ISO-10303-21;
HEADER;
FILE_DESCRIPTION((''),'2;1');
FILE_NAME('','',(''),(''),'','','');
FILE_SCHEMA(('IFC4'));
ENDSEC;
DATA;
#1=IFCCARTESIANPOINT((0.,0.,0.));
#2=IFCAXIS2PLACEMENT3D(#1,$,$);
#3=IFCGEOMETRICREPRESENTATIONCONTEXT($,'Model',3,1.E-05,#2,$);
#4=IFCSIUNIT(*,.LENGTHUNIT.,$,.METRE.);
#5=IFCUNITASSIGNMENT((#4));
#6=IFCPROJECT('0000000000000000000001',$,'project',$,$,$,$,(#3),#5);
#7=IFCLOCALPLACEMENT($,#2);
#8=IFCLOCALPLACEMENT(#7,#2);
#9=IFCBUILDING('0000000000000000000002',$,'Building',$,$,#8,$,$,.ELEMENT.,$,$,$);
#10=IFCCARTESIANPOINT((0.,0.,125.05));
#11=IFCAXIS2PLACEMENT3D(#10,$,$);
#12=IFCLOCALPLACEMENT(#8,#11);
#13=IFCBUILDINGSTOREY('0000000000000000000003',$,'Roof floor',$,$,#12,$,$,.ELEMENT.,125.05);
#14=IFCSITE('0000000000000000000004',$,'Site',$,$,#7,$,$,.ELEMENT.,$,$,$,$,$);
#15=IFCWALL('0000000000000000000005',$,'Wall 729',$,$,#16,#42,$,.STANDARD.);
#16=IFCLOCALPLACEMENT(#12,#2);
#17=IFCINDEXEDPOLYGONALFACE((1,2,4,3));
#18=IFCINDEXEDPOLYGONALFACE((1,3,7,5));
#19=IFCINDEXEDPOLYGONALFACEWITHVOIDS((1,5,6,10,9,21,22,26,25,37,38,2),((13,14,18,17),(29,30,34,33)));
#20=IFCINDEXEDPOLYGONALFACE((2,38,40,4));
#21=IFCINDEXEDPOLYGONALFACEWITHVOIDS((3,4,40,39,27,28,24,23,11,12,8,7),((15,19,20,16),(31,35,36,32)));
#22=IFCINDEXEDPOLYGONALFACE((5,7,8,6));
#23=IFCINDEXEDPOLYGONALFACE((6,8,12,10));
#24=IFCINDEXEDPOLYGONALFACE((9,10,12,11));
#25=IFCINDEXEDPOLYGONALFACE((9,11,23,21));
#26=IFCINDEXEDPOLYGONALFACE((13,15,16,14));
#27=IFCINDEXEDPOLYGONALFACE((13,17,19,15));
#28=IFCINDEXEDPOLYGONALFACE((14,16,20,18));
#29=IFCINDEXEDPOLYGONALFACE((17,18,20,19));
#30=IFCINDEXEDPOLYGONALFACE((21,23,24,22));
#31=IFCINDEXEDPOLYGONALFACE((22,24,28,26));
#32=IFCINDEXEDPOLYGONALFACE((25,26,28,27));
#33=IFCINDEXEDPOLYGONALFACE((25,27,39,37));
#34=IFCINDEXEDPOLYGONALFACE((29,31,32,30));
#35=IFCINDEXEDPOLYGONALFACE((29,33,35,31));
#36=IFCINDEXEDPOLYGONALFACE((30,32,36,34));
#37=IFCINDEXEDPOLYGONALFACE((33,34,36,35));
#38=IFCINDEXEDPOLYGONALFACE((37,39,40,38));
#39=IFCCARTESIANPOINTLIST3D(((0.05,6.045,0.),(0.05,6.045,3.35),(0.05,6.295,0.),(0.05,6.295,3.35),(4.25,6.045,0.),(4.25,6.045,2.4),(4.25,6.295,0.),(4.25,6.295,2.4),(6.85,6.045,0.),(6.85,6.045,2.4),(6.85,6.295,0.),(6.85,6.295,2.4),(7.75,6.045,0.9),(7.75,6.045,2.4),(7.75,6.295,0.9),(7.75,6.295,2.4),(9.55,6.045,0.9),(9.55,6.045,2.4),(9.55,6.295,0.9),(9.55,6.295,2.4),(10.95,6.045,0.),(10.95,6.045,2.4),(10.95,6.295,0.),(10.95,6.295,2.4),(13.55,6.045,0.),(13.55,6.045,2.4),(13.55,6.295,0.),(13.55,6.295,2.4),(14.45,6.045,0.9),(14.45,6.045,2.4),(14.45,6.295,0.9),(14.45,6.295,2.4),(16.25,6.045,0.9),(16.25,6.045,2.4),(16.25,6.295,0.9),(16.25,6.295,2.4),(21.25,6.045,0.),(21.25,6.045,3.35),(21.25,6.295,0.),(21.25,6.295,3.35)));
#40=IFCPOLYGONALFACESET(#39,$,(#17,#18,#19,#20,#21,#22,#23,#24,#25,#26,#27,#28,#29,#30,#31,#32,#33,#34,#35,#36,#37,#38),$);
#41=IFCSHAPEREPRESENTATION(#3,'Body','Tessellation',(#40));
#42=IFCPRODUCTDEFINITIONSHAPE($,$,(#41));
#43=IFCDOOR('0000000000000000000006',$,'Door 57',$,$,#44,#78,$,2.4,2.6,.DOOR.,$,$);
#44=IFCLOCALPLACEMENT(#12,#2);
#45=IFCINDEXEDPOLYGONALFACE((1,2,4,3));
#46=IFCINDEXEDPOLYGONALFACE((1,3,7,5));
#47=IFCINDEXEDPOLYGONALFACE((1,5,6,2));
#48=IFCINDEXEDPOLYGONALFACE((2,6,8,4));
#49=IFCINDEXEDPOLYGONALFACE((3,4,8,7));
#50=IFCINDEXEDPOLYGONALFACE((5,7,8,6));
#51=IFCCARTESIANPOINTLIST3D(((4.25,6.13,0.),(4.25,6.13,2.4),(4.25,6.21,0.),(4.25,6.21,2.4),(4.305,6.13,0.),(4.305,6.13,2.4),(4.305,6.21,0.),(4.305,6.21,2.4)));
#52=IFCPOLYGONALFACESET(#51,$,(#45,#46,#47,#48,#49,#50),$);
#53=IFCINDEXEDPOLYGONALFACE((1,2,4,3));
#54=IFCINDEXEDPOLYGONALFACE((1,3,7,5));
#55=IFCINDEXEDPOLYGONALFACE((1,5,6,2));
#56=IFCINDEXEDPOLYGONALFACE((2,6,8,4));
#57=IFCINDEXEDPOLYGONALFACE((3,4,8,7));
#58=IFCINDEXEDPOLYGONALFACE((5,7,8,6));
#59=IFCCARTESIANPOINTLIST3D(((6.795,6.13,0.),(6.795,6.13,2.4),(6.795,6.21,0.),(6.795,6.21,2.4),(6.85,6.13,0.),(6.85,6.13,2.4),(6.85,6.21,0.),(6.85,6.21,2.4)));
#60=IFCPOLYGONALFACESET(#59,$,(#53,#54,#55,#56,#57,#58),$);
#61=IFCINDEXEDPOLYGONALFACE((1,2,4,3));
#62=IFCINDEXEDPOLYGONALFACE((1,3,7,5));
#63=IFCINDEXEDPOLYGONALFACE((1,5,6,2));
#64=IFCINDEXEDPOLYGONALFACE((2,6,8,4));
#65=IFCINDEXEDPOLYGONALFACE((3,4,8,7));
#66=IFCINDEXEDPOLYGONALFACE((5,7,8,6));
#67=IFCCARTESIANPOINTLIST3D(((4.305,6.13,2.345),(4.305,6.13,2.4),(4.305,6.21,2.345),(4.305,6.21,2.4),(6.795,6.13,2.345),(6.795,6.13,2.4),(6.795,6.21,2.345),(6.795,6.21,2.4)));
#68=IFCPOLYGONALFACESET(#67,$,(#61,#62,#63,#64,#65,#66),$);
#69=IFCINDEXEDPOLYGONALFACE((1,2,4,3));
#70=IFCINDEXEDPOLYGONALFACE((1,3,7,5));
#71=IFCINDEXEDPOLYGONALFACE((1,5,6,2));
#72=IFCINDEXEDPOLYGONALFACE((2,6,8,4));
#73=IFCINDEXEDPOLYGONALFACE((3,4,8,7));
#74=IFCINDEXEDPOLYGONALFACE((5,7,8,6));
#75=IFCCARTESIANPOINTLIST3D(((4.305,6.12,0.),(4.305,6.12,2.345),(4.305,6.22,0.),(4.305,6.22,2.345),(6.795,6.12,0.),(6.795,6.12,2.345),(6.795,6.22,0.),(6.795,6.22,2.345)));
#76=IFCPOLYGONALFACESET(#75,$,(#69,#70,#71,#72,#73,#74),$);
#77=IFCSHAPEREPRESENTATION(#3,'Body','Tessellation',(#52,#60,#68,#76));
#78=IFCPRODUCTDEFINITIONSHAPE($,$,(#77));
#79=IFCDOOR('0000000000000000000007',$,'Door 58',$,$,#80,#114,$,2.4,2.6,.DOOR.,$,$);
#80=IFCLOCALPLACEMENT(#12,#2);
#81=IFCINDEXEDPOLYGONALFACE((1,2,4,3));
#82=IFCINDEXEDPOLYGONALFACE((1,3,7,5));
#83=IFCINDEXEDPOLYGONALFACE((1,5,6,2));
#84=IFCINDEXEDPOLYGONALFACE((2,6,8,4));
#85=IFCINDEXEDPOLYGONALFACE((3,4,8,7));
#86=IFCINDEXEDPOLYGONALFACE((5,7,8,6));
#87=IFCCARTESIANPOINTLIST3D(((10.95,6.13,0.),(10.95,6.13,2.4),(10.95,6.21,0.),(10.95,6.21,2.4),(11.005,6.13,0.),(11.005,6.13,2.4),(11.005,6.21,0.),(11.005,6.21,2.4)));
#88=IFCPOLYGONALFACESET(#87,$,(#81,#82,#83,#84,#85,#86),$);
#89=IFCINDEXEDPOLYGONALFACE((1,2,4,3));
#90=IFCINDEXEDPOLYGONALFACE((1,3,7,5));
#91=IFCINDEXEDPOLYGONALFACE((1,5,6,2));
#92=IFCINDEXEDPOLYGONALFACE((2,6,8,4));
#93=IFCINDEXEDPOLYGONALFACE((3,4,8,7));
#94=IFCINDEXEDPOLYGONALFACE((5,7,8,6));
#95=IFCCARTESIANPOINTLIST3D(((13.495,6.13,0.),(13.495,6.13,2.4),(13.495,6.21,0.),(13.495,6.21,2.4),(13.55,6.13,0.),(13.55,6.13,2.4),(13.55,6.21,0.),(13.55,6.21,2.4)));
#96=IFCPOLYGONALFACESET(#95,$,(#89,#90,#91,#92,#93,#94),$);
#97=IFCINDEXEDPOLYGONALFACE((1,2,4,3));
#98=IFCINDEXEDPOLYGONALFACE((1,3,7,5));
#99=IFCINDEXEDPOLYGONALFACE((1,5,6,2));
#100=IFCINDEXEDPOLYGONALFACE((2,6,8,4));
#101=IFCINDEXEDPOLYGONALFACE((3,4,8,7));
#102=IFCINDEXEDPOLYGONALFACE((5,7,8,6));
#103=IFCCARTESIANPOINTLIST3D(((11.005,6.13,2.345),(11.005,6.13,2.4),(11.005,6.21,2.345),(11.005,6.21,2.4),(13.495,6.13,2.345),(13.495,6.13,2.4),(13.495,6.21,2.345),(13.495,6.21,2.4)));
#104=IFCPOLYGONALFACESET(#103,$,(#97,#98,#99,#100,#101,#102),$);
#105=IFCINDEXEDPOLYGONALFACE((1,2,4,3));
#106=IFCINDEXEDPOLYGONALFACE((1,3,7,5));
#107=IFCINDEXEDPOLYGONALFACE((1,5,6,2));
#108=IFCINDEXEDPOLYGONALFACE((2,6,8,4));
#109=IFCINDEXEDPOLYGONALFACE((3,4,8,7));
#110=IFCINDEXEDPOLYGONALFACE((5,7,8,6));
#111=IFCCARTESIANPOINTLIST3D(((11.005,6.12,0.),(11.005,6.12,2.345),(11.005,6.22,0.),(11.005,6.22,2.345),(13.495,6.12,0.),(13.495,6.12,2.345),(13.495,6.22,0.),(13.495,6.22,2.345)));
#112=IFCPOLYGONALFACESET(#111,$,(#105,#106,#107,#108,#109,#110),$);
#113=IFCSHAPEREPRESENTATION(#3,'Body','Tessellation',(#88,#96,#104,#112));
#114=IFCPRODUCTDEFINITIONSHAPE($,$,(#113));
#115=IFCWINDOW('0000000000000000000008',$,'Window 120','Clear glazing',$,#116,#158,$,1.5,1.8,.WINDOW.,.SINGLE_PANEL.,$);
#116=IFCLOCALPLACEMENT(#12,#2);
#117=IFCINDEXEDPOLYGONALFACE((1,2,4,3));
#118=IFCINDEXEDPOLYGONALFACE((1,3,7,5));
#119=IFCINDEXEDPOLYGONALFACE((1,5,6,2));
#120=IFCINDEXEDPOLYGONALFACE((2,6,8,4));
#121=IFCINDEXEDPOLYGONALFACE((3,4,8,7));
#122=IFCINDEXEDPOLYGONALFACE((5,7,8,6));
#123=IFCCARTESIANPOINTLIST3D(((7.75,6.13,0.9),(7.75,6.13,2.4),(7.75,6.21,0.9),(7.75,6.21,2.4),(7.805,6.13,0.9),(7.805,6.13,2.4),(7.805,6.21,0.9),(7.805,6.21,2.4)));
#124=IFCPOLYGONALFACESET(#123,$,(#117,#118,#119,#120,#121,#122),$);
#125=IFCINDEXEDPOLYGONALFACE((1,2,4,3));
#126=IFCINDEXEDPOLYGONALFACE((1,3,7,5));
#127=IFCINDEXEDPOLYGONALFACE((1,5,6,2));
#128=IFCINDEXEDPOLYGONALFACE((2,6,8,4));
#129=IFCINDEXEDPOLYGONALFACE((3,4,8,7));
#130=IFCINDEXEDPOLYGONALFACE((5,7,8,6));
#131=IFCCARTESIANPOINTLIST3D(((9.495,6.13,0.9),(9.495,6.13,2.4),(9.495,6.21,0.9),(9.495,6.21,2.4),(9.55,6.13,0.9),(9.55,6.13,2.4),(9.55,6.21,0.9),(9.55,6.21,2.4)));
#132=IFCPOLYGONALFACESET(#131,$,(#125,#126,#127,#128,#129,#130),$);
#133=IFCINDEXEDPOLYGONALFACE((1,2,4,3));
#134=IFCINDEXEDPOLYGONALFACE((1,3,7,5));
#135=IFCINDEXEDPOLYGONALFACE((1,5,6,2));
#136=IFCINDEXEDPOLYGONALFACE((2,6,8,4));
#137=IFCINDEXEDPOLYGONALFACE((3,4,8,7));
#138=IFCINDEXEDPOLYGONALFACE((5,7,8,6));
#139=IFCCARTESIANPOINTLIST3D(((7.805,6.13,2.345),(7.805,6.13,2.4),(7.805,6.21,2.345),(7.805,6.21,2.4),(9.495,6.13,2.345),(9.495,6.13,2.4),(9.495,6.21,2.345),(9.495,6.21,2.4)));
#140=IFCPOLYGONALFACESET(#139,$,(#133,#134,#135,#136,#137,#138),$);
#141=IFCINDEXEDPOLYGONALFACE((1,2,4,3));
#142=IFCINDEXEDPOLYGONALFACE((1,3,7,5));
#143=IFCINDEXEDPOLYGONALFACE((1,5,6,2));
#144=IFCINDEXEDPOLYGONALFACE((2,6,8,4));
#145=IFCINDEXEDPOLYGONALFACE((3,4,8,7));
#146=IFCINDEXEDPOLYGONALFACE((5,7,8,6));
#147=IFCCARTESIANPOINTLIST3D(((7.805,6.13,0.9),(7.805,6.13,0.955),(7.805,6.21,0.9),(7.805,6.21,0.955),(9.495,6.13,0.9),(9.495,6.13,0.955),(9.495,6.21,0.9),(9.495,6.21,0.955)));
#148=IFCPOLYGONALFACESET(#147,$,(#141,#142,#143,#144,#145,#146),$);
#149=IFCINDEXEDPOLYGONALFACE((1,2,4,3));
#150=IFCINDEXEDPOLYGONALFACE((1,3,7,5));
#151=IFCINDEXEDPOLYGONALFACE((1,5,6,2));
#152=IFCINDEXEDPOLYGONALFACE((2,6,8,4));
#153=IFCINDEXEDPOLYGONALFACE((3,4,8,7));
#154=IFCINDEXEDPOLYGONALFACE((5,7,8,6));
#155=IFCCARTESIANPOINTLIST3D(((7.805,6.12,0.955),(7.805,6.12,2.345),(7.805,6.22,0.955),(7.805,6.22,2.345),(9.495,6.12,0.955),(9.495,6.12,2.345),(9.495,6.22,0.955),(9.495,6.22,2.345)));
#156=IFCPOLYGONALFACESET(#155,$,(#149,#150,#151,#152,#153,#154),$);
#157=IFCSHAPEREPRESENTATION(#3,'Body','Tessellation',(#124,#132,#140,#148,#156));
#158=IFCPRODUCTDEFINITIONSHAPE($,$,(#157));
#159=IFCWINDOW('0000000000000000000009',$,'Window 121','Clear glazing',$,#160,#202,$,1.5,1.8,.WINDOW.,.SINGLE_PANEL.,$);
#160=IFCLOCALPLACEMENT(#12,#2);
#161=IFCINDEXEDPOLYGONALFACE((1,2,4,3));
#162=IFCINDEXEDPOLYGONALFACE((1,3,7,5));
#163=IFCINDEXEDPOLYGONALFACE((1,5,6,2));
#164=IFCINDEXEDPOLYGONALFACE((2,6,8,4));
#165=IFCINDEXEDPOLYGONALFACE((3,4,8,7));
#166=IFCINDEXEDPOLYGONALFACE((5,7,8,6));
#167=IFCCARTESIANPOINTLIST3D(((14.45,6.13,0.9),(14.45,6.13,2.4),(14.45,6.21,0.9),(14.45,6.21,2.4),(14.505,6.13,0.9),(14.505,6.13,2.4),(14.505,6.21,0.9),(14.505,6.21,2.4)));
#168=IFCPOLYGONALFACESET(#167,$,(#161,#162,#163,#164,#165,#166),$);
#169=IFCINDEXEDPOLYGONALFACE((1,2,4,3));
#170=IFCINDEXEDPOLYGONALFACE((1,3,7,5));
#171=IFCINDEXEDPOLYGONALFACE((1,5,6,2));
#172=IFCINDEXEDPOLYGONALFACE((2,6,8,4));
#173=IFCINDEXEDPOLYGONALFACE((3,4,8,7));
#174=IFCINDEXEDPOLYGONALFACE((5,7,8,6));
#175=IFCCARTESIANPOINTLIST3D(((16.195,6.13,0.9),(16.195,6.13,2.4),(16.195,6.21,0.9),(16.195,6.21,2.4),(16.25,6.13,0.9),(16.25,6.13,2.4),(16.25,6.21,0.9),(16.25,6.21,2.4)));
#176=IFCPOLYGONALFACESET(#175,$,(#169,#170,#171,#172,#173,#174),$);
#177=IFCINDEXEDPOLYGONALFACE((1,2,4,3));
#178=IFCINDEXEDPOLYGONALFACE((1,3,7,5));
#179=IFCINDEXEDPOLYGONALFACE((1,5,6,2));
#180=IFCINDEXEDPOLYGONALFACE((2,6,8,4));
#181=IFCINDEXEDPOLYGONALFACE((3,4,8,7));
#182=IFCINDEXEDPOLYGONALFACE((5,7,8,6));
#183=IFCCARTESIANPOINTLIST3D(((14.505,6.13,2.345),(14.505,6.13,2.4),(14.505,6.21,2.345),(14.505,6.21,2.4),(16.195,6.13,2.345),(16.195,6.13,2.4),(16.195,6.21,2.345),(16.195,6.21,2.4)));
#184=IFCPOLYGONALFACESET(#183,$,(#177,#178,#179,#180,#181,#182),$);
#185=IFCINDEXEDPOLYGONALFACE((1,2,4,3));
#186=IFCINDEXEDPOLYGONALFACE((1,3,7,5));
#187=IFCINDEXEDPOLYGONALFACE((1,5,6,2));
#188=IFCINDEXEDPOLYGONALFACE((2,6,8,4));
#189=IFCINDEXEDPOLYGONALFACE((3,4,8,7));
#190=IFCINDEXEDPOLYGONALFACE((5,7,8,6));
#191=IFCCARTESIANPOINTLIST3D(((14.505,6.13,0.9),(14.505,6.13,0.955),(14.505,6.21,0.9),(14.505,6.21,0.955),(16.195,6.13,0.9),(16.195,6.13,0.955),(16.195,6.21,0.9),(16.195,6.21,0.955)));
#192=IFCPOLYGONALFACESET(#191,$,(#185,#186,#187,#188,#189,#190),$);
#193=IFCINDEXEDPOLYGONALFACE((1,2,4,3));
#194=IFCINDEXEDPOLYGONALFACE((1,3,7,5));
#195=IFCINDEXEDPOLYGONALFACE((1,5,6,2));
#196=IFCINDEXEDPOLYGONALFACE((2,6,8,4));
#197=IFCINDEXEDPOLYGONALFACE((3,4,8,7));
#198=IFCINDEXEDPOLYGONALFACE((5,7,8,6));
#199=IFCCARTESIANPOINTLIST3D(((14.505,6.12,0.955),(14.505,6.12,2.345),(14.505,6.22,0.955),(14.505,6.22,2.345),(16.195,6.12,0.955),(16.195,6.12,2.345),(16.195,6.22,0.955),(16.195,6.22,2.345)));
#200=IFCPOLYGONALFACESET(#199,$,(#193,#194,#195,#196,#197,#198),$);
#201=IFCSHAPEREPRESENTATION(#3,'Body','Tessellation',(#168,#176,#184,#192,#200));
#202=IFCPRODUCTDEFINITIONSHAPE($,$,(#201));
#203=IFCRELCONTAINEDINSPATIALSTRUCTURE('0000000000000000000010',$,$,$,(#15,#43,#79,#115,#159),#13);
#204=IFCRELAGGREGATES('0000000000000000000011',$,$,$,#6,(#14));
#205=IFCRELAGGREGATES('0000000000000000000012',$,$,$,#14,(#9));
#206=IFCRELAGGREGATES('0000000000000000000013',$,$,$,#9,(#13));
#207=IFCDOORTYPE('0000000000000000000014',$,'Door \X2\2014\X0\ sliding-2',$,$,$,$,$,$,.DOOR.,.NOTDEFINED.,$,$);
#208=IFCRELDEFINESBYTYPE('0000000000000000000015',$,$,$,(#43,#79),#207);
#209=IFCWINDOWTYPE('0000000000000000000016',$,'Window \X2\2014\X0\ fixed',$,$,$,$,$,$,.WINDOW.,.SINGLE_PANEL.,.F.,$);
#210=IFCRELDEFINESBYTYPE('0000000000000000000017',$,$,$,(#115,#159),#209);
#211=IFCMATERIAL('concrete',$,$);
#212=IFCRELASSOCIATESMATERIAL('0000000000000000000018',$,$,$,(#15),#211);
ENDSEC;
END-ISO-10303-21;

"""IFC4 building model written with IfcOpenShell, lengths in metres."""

from ifc_helpers import new_model, si_unit, frame, frame_2d, origin, place, context, project, spatial, rectangle, extrude, material, type_object, element, fill, save


model = new_model("IFC4")

# Units and contexts
model_context = context("Model", 3, precision=1e-05, world=origin())
ifc_project = project(units=[si_unit("LENGTHUNIT", "METRE")], contexts=[model_context])

# Site, building, storey
site_placement = place(None, origin())
site = spatial("IfcSite", under=ifc_project, at=site_placement, Name="Site", CompositionType="ELEMENT")
building_placement = place(site_placement, origin())
building = spatial("IfcBuilding", under=site, at=building_placement, Name="Building", CompositionType="ELEMENT")
storey_placement = place(building_placement, frame((0.0, 0.0, 125.05)))
storey = spatial("IfcBuildingStorey", under=building, at=storey_placement, Name="Roof floor", CompositionType="ELEMENT", Elevation=125.05)

# Shared definitions
ifc_material = material(Name="concrete")

# Wall, openings, doors, windows
wall_1_placement = place(storey_placement, frame((0.05, 6.17, 0.0), z_axis=(0.0, 0.0, 1.0), x_axis=(1.0, 0.0, 0.0)))
wall_1 = element("IfcWall", 1, at=wall_1_placement, inside=storey, material=ifc_material, Name="Wall 729", PredefinedType="STANDARD", context=model_context, shape_type="SweptSolid", body=[
    extrude(rectangle(XDim=21.2, YDim=0.25, at=frame_2d((10.6, 0.0))), origin(), (0.0, 0.0, 1.0), 3.35),
])
opening_1_placement = place(storey_placement, frame((4.25, 6.17, 0.0), z_axis=(0.0, 0.0, 1.0), x_axis=(1.0, 0.0, 0.0)))
opening_1 = element("IfcOpeningElement", 2, at=opening_1_placement, cuts=wall_1, PredefinedType="OPENING", context=model_context, shape_type="SweptSolid", body=[
    extrude(rectangle(XDim=2.6, YDim=0.31, at=frame_2d((1.3, 0.0))), origin(), (0.0, 0.0, 1.0), 2.4),
])
opening_2_placement = place(storey_placement, frame((7.75, 6.17, 0.9), z_axis=(0.0, 0.0, 1.0), x_axis=(1.0, 0.0, 0.0)))
opening_2 = element("IfcOpeningElement", 3, at=opening_2_placement, cuts=wall_1, PredefinedType="OPENING", context=model_context, shape_type="SweptSolid", body=[
    extrude(rectangle(XDim=1.8, YDim=0.31, at=frame_2d((0.9, 0.0))), origin(), (0.0, 0.0, 1.0), 1.5),
])
opening_3_placement = place(storey_placement, frame((10.95, 6.17, 0.0), z_axis=(0.0, 0.0, 1.0), x_axis=(1.0, 0.0, 0.0)))
opening_3 = element("IfcOpeningElement", 4, at=opening_3_placement, cuts=wall_1, PredefinedType="OPENING", context=model_context, shape_type="SweptSolid", body=[
    extrude(rectangle(XDim=2.6, YDim=0.31, at=frame_2d((1.3, 0.0))), origin(), (0.0, 0.0, 1.0), 2.4),
])
opening_4_placement = place(storey_placement, frame((14.45, 6.17, 0.9), z_axis=(0.0, 0.0, 1.0), x_axis=(1.0, 0.0, 0.0)))
opening_4 = element("IfcOpeningElement", 5, at=opening_4_placement, cuts=wall_1, PredefinedType="OPENING", context=model_context, shape_type="SweptSolid", body=[
    extrude(rectangle(XDim=1.8, YDim=0.31, at=frame_2d((0.9, 0.0))), origin(), (0.0, 0.0, 1.0), 1.5),
])
door_type = type_object("IfcDoorType", Name="Door — sliding-2", PredefinedType="DOOR")
door_1_placement = place(storey_placement, frame((4.25, 6.17, 0.0), z_axis=(0.0, 0.0, 1.0), x_axis=(1.0, 0.0, 0.0)))
door_1 = element("IfcDoor", 6, at=door_1_placement, inside=storey, type_object=door_type, Name="Door 57", OverallHeight=2.4, OverallWidth=2.6, PredefinedType="DOOR", context=model_context, shape_type="SweptSolid", body=[
    extrude(rectangle(XDim=0.055, YDim=0.08, at=frame_2d((0.0275, 0.0))), origin(), (0.0, 0.0, 1.0), 2.4),
    extrude(rectangle(XDim=0.055, YDim=0.08, at=frame_2d((2.5725, 0.0))), origin(), (0.0, 0.0, 1.0), 2.4),
    extrude(rectangle(XDim=2.49, YDim=0.08, at=frame_2d((1.3, 0.0))), frame((0.0, 0.0, 2.345)), (0.0, 0.0, 1.0), 0.055),
    extrude(rectangle(XDim=2.49, YDim=0.1, at=frame_2d((1.3, 0.0))), origin(), (0.0, 0.0, 1.0), 2.345),
])
fill(opening_1, door_1)
door_2_placement = place(storey_placement, frame((10.95, 6.17, 0.0), z_axis=(0.0, 0.0, 1.0), x_axis=(1.0, 0.0, 0.0)))
door_2 = element("IfcDoor", 7, at=door_2_placement, inside=storey, type_object=door_type, Name="Door 58", OverallHeight=2.4, OverallWidth=2.6, PredefinedType="DOOR", context=model_context, shape_type="SweptSolid", body=[
    extrude(rectangle(XDim=0.055, YDim=0.08, at=frame_2d((0.0275, 0.0))), origin(), (0.0, 0.0, 1.0), 2.4),
    extrude(rectangle(XDim=0.055, YDim=0.08, at=frame_2d((2.5725, 0.0))), origin(), (0.0, 0.0, 1.0), 2.4),
    extrude(rectangle(XDim=2.49, YDim=0.08, at=frame_2d((1.3, 0.0))), frame((0.0, 0.0, 2.345)), (0.0, 0.0, 1.0), 0.055),
    extrude(rectangle(XDim=2.49, YDim=0.1, at=frame_2d((1.3, 0.0))), origin(), (0.0, 0.0, 1.0), 2.345),
])
fill(opening_3, door_2)
window_type = type_object("IfcWindowType", Name="Window — fixed", ParameterTakesPrecedence=False, PartitioningType="SINGLE_PANEL", PredefinedType="WINDOW")
window_1_placement = place(storey_placement, frame((7.75, 6.17, 0.9), z_axis=(0.0, 0.0, 1.0), x_axis=(1.0, 0.0, 0.0)))
window_1 = element("IfcWindow", 8, at=window_1_placement, inside=storey, type_object=window_type, Name="Window 120", Description="Clear glazing", OverallHeight=1.5, OverallWidth=1.8, PartitioningType="SINGLE_PANEL", PredefinedType="WINDOW", context=model_context, shape_type="SweptSolid", body=[
    extrude(rectangle(XDim=0.055, YDim=0.08, at=frame_2d((0.0275, 0.0))), origin(), (0.0, 0.0, 1.0), 1.5),
    extrude(rectangle(XDim=0.055, YDim=0.08, at=frame_2d((1.7725, 0.0))), origin(), (0.0, 0.0, 1.0), 1.5),
    extrude(rectangle(XDim=1.69, YDim=0.08, at=frame_2d((0.9, 0.0))), frame((0.0, 0.0, 1.445)), (0.0, 0.0, 1.0), 0.055),
    extrude(rectangle(XDim=1.69, YDim=0.08, at=frame_2d((0.9, 0.0))), origin(), (0.0, 0.0, 1.0), 0.055),
    extrude(rectangle(XDim=1.69, YDim=0.1, at=frame_2d((0.9, 0.0))), frame((0.0, 0.0, 0.055)), (0.0, 0.0, 1.0), 1.39),
])
fill(opening_2, window_1)
window_2_placement = place(storey_placement, frame((14.45, 6.17, 0.9), z_axis=(0.0, 0.0, 1.0), x_axis=(1.0, 0.0, 0.0)))
window_2 = element("IfcWindow", 9, at=window_2_placement, inside=storey, type_object=window_type, Name="Window 121", Description="Clear glazing", OverallHeight=1.5, OverallWidth=1.8, PartitioningType="SINGLE_PANEL", PredefinedType="WINDOW", context=model_context, shape_type="SweptSolid", body=[
    extrude(rectangle(XDim=0.055, YDim=0.08, at=frame_2d((0.0275, 0.0))), origin(), (0.0, 0.0, 1.0), 1.5),
    extrude(rectangle(XDim=0.055, YDim=0.08, at=frame_2d((1.7725, 0.0))), origin(), (0.0, 0.0, 1.0), 1.5),
    extrude(rectangle(XDim=1.69, YDim=0.08, at=frame_2d((0.9, 0.0))), frame((0.0, 0.0, 1.445)), (0.0, 0.0, 1.0), 0.055),
    extrude(rectangle(XDim=1.69, YDim=0.08, at=frame_2d((0.9, 0.0))), origin(), (0.0, 0.0, 1.0), 0.055),
    extrude(rectangle(XDim=1.69, YDim=0.1, at=frame_2d((0.9, 0.0))), frame((0.0, 0.0, 0.055)), (0.0, 0.0, 1.0), 1.39),
])
fill(opening_4, window_2)

save(model, "model.ifc")
